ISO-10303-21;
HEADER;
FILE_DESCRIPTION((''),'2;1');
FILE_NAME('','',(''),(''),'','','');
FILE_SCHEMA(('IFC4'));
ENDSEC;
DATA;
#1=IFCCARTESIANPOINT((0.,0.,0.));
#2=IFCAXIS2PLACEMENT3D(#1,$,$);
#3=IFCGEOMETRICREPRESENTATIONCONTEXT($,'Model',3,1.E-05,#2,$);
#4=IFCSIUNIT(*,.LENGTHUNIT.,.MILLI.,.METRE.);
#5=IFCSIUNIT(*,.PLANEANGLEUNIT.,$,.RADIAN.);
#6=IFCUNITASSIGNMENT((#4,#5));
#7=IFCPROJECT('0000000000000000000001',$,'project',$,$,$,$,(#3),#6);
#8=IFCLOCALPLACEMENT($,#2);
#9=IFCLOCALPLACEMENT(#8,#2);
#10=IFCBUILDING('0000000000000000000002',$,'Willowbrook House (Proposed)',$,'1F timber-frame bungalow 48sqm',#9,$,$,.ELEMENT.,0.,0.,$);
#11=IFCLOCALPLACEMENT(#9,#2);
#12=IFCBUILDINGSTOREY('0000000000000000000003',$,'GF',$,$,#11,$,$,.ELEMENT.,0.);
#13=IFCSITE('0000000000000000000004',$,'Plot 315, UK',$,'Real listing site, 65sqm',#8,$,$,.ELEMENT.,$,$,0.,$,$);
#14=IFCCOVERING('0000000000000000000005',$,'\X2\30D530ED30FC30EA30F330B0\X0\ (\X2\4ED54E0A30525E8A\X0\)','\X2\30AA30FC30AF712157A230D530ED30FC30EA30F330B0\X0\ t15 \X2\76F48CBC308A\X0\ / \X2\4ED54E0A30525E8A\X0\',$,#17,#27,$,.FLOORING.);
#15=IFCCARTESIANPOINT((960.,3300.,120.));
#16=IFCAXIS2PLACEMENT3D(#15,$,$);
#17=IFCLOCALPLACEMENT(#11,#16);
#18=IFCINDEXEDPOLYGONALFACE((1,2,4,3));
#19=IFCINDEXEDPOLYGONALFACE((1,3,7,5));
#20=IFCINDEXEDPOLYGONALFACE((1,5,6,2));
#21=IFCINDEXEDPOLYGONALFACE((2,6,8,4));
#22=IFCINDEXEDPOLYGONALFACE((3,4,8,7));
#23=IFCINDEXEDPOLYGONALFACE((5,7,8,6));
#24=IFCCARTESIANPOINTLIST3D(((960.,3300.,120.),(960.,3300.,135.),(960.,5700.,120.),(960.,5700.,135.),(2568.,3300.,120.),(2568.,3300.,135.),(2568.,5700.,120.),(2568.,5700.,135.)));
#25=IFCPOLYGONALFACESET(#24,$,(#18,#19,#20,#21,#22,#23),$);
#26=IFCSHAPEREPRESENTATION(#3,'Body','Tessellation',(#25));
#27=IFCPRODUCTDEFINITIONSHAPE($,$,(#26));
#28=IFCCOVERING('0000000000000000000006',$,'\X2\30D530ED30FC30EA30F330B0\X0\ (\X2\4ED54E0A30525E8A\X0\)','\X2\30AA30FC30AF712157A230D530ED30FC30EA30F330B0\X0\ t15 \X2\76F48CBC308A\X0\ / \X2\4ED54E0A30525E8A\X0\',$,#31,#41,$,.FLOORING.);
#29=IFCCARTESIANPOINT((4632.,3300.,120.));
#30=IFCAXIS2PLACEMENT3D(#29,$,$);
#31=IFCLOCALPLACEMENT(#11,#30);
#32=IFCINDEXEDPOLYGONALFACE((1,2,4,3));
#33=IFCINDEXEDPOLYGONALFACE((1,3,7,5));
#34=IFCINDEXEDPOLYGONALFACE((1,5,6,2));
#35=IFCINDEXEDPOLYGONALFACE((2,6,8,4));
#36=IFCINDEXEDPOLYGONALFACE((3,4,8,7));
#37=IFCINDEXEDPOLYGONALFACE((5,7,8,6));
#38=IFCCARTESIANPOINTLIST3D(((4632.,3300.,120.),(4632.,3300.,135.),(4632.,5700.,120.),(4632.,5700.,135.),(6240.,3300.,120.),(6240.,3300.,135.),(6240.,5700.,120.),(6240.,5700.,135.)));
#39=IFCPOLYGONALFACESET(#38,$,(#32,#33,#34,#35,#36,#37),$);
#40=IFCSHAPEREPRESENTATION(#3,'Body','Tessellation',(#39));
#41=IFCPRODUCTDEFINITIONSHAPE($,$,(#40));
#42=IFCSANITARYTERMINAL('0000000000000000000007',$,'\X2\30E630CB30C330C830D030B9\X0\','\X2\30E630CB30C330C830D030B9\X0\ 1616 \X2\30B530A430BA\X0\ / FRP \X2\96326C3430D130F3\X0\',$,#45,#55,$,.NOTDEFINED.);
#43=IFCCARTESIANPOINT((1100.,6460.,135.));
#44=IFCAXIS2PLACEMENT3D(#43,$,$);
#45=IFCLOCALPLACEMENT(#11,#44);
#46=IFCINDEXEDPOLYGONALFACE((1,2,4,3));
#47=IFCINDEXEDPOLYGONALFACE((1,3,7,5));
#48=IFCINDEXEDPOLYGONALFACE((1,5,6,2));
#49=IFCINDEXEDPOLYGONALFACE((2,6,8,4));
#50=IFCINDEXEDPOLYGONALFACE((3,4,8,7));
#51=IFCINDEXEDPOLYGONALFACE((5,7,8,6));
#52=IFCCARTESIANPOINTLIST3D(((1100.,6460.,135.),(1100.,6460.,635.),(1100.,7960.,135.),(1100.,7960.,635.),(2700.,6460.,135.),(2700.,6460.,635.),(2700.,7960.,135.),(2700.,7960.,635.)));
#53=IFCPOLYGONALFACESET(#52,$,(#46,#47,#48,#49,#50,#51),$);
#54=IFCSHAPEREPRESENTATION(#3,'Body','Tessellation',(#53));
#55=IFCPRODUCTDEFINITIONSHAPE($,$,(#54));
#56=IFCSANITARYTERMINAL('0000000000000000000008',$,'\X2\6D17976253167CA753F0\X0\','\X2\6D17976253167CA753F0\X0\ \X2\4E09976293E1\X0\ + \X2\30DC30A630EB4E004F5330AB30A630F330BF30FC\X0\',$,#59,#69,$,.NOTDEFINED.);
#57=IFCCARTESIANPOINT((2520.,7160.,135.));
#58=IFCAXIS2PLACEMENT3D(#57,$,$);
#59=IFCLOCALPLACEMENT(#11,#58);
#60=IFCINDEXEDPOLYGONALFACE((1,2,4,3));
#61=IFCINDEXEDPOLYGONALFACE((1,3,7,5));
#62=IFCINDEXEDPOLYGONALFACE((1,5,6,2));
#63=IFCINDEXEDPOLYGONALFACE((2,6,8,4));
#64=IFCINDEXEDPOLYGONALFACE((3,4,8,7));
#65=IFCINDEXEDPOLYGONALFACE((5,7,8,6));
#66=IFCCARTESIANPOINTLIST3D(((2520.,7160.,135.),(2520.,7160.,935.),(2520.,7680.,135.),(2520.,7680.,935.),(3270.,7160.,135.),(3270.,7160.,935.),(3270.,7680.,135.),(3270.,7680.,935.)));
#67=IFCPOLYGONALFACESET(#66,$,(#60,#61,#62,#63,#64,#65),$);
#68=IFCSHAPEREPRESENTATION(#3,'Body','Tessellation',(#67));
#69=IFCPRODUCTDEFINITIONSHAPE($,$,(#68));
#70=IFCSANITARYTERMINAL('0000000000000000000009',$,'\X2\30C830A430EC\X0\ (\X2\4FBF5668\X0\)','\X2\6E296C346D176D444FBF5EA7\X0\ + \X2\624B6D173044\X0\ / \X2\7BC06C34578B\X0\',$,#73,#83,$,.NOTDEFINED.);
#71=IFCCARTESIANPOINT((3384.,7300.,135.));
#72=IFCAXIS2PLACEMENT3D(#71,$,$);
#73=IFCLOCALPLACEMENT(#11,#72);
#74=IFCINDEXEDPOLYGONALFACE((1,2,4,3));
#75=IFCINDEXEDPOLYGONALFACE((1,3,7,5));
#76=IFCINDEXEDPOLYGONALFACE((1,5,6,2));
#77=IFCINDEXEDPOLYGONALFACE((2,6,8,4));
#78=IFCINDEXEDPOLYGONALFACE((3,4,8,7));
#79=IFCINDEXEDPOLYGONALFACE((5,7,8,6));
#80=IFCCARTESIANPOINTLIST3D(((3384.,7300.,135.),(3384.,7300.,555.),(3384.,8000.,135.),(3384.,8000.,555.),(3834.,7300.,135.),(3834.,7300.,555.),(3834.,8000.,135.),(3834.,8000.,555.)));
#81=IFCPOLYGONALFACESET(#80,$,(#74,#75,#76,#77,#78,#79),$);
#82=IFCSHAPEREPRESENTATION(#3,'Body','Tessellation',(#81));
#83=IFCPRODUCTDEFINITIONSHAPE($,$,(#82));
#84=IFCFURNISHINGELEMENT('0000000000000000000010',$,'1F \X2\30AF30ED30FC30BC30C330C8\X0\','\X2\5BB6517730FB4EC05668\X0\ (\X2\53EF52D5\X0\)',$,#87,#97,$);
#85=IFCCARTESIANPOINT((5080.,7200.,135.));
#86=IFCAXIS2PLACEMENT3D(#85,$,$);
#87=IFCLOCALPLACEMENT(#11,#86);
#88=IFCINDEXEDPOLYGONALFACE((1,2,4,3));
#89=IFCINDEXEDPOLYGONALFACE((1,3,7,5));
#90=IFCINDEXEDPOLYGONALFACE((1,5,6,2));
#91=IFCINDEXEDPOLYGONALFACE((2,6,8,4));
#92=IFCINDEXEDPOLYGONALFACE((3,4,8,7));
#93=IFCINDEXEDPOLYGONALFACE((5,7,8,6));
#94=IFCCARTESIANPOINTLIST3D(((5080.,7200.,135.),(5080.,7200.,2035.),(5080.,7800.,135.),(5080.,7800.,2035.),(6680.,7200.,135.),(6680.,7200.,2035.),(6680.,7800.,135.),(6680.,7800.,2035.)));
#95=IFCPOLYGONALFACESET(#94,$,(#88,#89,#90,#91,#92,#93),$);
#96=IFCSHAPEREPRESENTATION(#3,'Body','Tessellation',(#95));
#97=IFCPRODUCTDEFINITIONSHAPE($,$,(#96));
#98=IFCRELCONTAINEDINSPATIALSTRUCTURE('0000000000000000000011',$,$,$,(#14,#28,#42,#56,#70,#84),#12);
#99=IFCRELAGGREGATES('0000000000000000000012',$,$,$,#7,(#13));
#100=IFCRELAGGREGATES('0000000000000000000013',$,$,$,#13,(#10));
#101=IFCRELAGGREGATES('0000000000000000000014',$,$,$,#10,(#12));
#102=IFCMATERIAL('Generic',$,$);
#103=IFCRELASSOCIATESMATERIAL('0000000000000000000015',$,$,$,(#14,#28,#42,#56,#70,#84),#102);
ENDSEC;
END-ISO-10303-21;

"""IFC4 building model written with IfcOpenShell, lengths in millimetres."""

from ifc_helpers import new_model, si_unit, frame, frame_2d, origin, place, context, project, spatial, rectangle, extrude, material, element, save


model = new_model("IFC4")

# Units and contexts
model_context = context("Model", 3, precision=1e-05, world=origin())
ifc_project = project(units=[si_unit("LENGTHUNIT", "METRE", prefix="MILLI"), si_unit("PLANEANGLEUNIT", "RADIAN")], contexts=[model_context])

# Site, building, storey
site_placement = place(None, origin())
site = spatial("IfcSite", under=ifc_project, at=site_placement, Name="Plot 315, UK", ObjectType="Real listing site, 65sqm", CompositionType="ELEMENT", RefElevation=0.0)
building_placement = place(site_placement, origin())
building = spatial("IfcBuilding", under=site, at=building_placement, Name="Willowbrook House (Proposed)", ObjectType="1F timber-frame bungalow 48sqm", CompositionType="ELEMENT", ElevationOfRefHeight=0.0, ElevationOfTerrain=0.0)
storey_placement = place(building_placement, origin())
storey = spatial("IfcBuildingStorey", under=building, at=storey_placement, Name="GF", CompositionType="ELEMENT", Elevation=0.0)

# Coverings
ifc_material_1 = material(Name="Generic")
covering_1_placement = place(storey_placement, frame((960.0, 3300.0, 120.0)))
element("IfcCovering", 1, at=covering_1_placement, inside=storey, material=ifc_material_1, Name="フローリング (仕上げ床)", Description="オーク無垢フローリング t15 直貼り / 仕上げ床", PredefinedType="FLOORING", context=model_context, shape_type="SweptSolid", body=[
    extrude(rectangle(XDim=1608.0, YDim=2400.0, at=frame_2d((804.0, 1200.0))), frame((960.0, 3300.0, 120.0)), (0.0, 0.0, 1.0), 15.0),
])
covering_2_placement = place(storey_placement, frame((4632.0, 3300.0, 120.0)))
element("IfcCovering", 2, at=covering_2_placement, inside=storey, material=ifc_material_1, Name="フローリング (仕上げ床)", Description="オーク無垢フローリング t15 直貼り / 仕上げ床", PredefinedType="FLOORING", context=model_context, shape_type="SweptSolid", body=[
    extrude(rectangle(XDim=1608.0, YDim=2400.0, at=frame_2d((804.0, 1200.0))), frame((4632.0, 3300.0, 120.0)), (0.0, 0.0, 1.0), 15.0),
])

# Sanitary terminals
sanitary_terminal_1_placement = place(storey_placement, frame((1100.0, 6460.0, 135.0)))
element("IfcSanitaryTerminal", 3, at=sanitary_terminal_1_placement, inside=storey, material=ifc_material_1, Name="ユニットバス", Description="ユニットバス 1616 サイズ / FRP 防水パン", PredefinedType="NOTDEFINED", context=model_context, shape_type="SweptSolid", body=[
    extrude(rectangle(XDim=1600.0, YDim=1500.0, at=frame_2d((800.0, 750.0))), frame((1100.0, 6460.0, 135.0)), (0.0, 0.0, 1.0), 500.0),
])
sanitary_terminal_2_placement = place(storey_placement, frame((2520.0, 7160.0, 135.0)))
element("IfcSanitaryTerminal", 4, at=sanitary_terminal_2_placement, inside=storey, material=ifc_material_1, Name="洗面化粧台", Description="洗面化粧台 三面鏡 + ボウル一体カウンター", PredefinedType="NOTDEFINED", context=model_context, shape_type="SweptSolid", body=[
    extrude(rectangle(XDim=750.0, YDim=520.0, at=frame_2d((375.0, 260.0))), frame((2520.0, 7160.0, 135.0)), (0.0, 0.0, 1.0), 800.0),
])
sanitary_terminal_3_placement = place(storey_placement, frame((3384.0, 7300.0, 135.0)))
element("IfcSanitaryTerminal", 5, at=sanitary_terminal_3_placement, inside=storey, material=ifc_material_1, Name="トイレ (便器)", Description="温水洗浄便座 + 手洗い / 節水型", PredefinedType="NOTDEFINED", context=model_context, shape_type="SweptSolid", body=[
    extrude(rectangle(XDim=450.0, YDim=700.0, at=frame_2d((225.0, 350.0))), frame((3384.0, 7300.0, 135.0)), (0.0, 0.0, 1.0), 420.0),
])

# Furnishing element
furnishing_placement = place(storey_placement, frame((5080.0, 7200.0, 135.0)))
element("IfcFurnishingElement", 6, at=furnishing_placement, inside=storey, material=ifc_material_1, Name="1F クローゼット", Description="家具・什器 (可動)", context=model_context, shape_type="SweptSolid", body=[
    extrude(rectangle(XDim=1600.0, YDim=600.0, at=frame_2d((800.0, 300.0))), frame((5080.0, 7200.0, 135.0)), (0.0, 0.0, 1.0), 1900.0),
])

save(model, "model.ifc")
